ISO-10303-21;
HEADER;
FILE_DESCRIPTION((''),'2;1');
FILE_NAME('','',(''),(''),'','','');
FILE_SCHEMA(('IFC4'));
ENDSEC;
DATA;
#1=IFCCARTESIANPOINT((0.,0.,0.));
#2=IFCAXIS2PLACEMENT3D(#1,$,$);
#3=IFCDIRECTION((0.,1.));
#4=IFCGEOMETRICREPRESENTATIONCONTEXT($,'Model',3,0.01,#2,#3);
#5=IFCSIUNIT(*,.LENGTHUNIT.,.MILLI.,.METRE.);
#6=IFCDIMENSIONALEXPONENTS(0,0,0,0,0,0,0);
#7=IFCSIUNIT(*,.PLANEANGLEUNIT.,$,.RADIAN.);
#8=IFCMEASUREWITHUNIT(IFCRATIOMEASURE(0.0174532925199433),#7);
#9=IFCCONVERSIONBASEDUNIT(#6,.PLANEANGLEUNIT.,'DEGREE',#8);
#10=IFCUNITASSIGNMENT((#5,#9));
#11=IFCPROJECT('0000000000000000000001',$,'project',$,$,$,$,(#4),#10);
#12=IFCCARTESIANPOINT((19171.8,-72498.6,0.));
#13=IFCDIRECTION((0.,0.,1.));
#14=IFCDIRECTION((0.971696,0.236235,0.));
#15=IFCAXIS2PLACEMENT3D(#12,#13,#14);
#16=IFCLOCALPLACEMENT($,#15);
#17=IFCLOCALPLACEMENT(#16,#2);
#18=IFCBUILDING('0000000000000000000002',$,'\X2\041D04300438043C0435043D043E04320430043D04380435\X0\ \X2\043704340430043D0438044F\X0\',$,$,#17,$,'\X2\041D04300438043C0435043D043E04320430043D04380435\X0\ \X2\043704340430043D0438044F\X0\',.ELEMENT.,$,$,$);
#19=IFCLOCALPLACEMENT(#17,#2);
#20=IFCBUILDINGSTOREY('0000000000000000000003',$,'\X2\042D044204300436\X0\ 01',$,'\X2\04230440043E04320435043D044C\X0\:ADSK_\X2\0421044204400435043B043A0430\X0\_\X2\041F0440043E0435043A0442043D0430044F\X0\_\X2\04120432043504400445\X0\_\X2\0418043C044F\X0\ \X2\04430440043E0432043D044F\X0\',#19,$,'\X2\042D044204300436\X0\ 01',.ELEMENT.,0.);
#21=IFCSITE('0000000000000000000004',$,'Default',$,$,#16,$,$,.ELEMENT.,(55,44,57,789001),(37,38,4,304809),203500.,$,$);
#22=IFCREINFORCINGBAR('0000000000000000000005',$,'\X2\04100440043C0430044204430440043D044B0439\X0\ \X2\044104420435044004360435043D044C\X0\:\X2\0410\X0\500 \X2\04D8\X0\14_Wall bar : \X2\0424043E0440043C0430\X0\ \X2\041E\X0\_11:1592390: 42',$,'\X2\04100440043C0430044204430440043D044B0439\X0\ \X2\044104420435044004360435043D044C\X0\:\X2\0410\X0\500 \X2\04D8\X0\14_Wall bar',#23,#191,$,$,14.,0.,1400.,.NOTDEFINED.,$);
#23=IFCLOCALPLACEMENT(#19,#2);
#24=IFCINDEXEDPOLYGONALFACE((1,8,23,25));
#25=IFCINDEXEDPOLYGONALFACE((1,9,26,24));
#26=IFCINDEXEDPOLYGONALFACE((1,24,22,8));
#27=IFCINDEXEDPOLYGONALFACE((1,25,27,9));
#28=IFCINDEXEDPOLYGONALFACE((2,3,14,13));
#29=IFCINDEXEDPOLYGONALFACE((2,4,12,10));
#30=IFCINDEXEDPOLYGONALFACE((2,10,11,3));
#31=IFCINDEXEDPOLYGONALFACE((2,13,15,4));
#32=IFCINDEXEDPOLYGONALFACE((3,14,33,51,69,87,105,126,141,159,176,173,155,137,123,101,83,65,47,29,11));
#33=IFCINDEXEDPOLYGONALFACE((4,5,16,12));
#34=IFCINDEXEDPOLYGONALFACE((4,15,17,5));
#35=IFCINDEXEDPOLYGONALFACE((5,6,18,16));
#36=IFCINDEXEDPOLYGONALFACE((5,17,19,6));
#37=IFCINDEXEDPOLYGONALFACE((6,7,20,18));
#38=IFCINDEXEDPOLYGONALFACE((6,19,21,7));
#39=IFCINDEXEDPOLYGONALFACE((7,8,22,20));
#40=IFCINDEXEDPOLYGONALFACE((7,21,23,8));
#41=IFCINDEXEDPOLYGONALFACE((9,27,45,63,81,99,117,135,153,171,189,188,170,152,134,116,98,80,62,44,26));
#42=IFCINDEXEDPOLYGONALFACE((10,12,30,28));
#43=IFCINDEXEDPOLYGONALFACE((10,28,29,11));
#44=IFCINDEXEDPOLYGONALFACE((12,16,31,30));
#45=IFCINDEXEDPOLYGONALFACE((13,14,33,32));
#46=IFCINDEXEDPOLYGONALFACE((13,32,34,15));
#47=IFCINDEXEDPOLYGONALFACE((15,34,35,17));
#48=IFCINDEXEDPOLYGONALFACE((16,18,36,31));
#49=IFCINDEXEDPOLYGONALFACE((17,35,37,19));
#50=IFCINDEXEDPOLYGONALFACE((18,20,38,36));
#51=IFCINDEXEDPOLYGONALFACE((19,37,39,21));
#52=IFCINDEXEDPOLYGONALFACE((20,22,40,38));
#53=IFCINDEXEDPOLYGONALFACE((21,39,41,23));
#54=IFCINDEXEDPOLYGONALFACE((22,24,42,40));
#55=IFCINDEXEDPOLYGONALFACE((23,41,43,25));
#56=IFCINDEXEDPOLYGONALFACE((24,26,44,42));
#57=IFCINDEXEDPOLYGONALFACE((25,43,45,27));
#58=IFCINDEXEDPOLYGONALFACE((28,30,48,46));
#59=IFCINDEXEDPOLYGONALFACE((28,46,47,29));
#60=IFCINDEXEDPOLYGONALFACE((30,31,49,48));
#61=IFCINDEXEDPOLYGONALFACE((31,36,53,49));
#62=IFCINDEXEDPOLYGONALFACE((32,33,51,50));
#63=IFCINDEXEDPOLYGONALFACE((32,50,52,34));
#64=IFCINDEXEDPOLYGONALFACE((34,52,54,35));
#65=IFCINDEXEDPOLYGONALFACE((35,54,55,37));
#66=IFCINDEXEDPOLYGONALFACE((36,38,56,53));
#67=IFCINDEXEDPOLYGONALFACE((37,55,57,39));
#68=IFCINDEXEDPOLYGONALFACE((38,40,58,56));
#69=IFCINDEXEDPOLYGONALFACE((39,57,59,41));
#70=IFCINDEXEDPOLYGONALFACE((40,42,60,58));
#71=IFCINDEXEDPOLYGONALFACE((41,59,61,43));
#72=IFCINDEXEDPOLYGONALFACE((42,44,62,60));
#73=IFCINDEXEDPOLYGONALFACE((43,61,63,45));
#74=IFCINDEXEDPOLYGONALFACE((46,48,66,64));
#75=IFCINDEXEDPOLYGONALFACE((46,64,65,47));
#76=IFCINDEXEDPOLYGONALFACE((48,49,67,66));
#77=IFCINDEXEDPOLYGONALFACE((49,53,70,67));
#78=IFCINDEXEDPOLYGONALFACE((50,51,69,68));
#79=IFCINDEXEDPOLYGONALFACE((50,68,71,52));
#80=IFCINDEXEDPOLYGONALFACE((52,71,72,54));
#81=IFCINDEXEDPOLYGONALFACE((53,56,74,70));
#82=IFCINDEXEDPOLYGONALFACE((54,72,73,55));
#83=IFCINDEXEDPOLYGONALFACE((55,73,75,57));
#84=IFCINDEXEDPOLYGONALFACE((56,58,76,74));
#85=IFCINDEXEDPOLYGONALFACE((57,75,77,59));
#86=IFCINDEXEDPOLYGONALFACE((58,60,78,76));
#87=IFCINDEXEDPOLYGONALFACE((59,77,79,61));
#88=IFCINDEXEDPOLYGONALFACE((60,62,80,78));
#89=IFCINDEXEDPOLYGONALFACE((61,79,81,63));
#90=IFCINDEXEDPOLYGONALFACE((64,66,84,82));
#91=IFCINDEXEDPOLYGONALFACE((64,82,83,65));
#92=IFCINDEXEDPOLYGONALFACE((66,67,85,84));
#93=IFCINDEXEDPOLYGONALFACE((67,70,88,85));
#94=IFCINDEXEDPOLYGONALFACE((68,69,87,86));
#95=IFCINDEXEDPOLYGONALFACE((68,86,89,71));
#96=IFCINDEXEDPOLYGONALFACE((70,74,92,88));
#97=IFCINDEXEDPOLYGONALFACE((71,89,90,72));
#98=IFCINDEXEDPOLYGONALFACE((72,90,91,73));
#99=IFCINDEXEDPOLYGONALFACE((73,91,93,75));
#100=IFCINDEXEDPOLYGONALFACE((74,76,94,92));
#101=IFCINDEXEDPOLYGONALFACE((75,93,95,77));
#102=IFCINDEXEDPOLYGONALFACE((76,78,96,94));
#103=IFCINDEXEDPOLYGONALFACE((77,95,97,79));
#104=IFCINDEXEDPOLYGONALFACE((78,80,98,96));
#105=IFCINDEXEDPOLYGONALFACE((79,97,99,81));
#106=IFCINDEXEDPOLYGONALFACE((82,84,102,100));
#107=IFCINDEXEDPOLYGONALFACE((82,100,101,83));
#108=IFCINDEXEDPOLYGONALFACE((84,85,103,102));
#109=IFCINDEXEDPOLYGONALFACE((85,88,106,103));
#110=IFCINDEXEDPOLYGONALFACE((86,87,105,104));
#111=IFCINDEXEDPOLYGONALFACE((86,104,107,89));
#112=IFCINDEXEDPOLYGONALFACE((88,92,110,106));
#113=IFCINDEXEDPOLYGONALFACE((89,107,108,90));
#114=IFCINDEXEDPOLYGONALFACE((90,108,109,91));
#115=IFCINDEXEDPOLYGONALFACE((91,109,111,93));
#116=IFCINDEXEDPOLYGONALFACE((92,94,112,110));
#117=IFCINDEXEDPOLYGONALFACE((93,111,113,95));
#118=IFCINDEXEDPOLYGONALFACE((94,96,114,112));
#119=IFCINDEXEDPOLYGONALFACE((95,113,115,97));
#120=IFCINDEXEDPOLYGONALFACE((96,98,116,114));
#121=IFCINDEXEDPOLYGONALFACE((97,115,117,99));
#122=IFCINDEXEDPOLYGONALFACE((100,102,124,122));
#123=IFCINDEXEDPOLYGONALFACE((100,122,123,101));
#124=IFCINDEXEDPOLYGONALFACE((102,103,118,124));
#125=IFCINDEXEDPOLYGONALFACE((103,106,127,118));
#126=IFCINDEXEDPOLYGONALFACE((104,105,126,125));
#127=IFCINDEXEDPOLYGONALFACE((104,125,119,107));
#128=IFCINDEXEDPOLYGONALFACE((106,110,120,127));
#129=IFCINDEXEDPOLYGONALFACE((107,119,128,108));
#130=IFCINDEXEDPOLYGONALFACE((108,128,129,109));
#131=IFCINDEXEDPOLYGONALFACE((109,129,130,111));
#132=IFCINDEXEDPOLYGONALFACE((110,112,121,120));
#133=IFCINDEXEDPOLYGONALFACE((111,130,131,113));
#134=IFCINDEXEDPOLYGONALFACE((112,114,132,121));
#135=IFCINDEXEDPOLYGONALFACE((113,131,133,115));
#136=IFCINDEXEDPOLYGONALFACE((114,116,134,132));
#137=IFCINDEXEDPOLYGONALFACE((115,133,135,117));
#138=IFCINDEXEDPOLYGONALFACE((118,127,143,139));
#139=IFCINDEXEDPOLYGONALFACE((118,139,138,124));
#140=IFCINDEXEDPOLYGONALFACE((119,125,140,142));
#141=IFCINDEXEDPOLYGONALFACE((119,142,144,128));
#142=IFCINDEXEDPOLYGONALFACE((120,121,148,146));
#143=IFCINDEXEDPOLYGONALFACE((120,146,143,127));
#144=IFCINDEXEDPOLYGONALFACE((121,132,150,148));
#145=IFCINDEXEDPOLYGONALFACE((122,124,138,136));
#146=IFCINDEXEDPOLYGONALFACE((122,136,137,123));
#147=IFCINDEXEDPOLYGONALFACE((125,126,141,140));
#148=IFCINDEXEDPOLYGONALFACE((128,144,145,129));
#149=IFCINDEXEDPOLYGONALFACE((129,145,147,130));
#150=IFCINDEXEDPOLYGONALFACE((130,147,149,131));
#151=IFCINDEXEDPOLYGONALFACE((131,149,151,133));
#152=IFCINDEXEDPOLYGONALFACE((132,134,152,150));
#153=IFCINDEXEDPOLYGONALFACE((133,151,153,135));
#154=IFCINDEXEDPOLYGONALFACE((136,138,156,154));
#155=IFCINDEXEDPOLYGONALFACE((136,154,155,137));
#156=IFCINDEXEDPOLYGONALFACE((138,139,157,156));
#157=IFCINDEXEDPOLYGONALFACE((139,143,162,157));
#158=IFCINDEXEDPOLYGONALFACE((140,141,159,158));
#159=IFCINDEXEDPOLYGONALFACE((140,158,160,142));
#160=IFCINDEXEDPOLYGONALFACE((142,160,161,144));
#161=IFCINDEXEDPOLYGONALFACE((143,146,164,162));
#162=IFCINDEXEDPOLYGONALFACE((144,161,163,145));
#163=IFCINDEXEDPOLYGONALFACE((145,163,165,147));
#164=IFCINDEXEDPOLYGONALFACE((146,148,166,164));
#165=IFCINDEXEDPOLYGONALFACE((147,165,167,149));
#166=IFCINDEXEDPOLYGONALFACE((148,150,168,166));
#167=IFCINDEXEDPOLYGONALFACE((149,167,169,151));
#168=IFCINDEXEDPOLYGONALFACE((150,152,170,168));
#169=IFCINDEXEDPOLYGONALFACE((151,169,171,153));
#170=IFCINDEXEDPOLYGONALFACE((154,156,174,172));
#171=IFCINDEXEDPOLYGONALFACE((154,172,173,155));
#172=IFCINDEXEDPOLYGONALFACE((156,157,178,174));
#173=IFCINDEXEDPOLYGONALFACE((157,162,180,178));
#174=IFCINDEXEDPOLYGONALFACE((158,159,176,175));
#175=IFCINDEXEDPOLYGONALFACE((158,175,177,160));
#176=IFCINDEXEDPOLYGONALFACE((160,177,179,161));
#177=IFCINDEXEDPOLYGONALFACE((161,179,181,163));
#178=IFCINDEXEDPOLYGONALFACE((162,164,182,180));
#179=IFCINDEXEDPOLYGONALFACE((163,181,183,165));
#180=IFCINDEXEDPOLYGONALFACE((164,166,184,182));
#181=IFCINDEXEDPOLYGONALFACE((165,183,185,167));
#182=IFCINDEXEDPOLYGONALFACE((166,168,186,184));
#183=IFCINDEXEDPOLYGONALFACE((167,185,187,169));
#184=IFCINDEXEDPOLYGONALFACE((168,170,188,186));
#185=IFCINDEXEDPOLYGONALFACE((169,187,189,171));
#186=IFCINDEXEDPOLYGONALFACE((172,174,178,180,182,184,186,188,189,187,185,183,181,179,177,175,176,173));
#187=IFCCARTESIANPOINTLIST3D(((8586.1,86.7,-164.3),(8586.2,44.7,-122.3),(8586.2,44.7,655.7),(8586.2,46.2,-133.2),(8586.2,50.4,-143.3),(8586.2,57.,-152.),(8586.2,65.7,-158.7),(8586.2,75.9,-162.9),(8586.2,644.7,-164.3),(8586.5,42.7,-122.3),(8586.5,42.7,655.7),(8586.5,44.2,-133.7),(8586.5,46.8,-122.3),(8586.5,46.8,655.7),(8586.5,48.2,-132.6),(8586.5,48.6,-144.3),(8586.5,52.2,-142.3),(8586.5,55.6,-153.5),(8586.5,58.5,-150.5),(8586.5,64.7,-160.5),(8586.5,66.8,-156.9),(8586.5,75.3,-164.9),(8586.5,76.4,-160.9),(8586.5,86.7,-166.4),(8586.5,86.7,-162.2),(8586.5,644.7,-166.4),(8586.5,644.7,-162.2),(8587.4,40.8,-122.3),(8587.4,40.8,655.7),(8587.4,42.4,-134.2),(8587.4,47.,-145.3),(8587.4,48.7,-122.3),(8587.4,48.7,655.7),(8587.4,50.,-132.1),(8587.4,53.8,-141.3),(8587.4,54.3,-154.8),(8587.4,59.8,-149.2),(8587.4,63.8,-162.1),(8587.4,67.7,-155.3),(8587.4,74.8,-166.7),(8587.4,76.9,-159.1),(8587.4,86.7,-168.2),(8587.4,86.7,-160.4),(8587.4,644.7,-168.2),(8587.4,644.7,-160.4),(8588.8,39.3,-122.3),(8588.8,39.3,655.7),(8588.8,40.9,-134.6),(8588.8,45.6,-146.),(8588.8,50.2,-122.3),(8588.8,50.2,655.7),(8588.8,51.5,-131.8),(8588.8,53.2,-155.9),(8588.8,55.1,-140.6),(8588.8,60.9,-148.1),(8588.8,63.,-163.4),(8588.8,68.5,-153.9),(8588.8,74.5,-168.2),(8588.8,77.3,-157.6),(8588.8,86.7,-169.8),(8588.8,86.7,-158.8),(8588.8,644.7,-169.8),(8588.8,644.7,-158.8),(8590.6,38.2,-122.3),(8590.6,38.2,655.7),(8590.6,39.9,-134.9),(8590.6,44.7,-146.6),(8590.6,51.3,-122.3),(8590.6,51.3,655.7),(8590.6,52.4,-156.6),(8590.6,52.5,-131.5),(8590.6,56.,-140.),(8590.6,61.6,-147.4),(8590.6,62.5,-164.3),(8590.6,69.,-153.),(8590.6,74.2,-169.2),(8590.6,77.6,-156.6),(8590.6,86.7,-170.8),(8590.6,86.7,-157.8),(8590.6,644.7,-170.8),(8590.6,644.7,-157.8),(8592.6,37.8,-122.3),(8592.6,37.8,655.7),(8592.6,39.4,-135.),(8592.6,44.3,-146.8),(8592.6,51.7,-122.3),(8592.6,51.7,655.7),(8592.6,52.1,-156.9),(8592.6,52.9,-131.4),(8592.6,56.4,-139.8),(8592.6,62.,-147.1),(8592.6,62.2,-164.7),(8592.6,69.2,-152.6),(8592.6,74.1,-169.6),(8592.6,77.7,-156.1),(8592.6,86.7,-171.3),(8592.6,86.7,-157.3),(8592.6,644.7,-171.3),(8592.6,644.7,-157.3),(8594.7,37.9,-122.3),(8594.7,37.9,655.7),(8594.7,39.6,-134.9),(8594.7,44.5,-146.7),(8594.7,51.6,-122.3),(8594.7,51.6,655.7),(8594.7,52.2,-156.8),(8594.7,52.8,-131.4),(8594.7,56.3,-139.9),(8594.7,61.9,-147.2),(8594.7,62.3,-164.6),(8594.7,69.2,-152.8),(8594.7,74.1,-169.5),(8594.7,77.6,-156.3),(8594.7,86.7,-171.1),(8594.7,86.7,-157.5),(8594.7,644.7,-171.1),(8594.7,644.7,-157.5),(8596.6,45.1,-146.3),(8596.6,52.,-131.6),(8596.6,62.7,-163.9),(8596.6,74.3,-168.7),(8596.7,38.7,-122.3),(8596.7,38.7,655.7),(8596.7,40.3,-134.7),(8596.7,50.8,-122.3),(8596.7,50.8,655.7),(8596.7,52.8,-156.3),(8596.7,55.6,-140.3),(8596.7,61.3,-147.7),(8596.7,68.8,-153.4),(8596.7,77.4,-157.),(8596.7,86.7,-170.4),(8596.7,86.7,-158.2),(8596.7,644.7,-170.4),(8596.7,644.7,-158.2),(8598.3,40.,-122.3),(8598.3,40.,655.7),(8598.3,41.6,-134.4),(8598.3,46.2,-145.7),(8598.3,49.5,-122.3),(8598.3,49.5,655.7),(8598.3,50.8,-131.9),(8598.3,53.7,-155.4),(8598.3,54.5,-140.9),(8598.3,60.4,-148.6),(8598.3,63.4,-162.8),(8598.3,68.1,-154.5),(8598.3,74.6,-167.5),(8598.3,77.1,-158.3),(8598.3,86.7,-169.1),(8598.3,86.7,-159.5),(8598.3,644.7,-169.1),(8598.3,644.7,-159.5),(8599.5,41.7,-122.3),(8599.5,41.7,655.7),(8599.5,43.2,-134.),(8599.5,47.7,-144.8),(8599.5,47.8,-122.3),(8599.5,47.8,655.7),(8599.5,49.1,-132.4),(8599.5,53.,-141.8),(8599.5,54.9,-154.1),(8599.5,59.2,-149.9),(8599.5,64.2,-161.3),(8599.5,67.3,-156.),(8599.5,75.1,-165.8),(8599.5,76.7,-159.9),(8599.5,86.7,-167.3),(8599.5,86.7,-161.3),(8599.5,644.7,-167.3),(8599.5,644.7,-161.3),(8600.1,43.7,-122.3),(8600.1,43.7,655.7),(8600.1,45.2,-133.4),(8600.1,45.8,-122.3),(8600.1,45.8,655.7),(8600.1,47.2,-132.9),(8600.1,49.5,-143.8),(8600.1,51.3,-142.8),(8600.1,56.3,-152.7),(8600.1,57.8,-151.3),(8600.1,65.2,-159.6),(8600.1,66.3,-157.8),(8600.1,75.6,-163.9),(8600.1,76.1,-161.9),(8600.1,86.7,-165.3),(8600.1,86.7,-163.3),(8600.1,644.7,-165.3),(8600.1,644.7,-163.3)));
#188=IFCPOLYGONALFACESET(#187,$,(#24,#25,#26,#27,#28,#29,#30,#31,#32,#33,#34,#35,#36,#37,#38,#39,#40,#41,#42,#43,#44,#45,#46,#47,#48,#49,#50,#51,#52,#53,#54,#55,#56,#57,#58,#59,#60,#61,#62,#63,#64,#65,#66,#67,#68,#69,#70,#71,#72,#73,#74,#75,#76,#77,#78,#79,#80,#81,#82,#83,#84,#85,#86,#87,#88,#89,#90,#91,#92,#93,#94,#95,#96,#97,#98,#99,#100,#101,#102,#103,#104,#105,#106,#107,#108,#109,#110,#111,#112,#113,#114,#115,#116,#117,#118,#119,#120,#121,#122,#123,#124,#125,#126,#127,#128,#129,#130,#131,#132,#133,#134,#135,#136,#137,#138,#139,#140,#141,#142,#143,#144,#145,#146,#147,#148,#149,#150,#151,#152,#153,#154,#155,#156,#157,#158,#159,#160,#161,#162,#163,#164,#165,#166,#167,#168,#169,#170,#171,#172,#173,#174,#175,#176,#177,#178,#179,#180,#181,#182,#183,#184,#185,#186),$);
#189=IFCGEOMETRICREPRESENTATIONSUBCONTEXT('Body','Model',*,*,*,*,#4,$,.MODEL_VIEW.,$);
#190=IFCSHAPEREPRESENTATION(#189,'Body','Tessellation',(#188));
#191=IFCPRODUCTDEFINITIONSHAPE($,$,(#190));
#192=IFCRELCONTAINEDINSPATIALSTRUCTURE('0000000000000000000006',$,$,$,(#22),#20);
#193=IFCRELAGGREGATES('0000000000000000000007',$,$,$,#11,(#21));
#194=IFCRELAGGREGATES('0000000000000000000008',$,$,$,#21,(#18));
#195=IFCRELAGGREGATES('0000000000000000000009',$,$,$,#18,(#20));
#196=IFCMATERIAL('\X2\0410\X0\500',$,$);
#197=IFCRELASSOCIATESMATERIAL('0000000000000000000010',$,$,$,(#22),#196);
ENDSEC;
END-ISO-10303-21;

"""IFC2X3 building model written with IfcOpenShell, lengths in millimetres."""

from ifc_helpers import new_model, entity, si_unit, converted_unit, direction, frame, origin, place, context, subcontext, project, spatial, material, element, save


model = new_model("IFC2X3")

# Units and contexts
model_context = context("Model", 3, precision=0.01, world=origin(), true_north=direction((0.0, 1.0)))
body_context = subcontext(model_context, "Body", "Model", "MODEL_VIEW")
ifc_project = project(units=[si_unit("LENGTHUNIT", "METRE", prefix="MILLI"), converted_unit("PLANEANGLEUNIT", "DEGREE", entity("IfcRatioMeasure", 0.0174532925199433), si_unit("PLANEANGLEUNIT", "RADIAN"), dimensions=[0, 0, 0, 0, 0, 0, 0])], contexts=[model_context])

# Site, building, storey
site_placement = place(None, frame((19171.8, -72498.6, 0.0), z_axis=(0.0, 0.0, 1.0), x_axis=(0.971696, 0.236235, 0.0)))
site = spatial("IfcSite", under=ifc_project, at=site_placement, Name="Default", CompositionType="ELEMENT", RefLatitude=(55, 44, 57, 789001), RefLongitude=(37, 38, 4, 304809), RefElevation=203500.0)
building_placement = place(site_placement, origin())
building = spatial("IfcBuilding", under=site, at=building_placement, Name="Наименование здания", LongName="Наименование здания", CompositionType="ELEMENT")
storey_placement = place(building_placement, origin())
storey = spatial("IfcBuildingStorey", under=building, at=storey_placement, Name="Этаж 01", ObjectType="Уровень:ADSK_Стрелка_Проектная_Вверх_Имя уровня", LongName="Этаж 01", CompositionType="ELEMENT", Elevation=0.0)

# Reinforcing bar
ifc_material = material(Name="А500")
placement = place(storey_placement, origin())
element("IfcReinforcingBar", 1, at=placement, inside=storey, material=ifc_material, Name="Арматурный стержень:А500 Ә14_Wall bar : Форма О_11:1592390: 42", ObjectType="Арматурный стержень:А500 Ә14_Wall bar", BarLength=1400.0, BarRole="NOTDEFINED", CrossSectionArea=0.0, NominalDiameter=14.0, context=body_context, shape_type="AdvancedSweptSolid", body=[
    entity("IfcSweptDiskSolid", entity("IfcCompositeCurve", [entity("IfcCompositeCurveSegment", "CONTINUOUS", True, entity("IfcPolyline", [entity("IfcCartesianPoint", [8593.1, 44.7, 655.7]), entity("IfcCartesianPoint", [8593.1, 44.7, -122.3])])), entity("IfcCompositeCurveSegment", "CONTINUOUS", True, entity("IfcTrimmedCurve", entity("IfcCircle", entity("IfcAxis2Placement3D", entity("IfcCartesianPoint", [8593.1, 86.7, -122.3]), entity("IfcDirection", [1.0, 0.0, 0.0]), entity("IfcDirection", [0.0, 0.0, -1.0])), 42.0), [entity("IfcParameterValue", 270.0)], [entity("IfcParameterValue", 360.0)], True, "PARAMETER")), entity("IfcCompositeCurveSegment", "CONTINUOUS", True, entity("IfcPolyline", [entity("IfcCartesianPoint", [8593.1, 86.7, -164.3]), entity("IfcCartesianPoint", [8593.1, 644.7, -164.3])]))], False), 7.0, None, 0.0, 92.0),
])

save(model, "model.ifc")
